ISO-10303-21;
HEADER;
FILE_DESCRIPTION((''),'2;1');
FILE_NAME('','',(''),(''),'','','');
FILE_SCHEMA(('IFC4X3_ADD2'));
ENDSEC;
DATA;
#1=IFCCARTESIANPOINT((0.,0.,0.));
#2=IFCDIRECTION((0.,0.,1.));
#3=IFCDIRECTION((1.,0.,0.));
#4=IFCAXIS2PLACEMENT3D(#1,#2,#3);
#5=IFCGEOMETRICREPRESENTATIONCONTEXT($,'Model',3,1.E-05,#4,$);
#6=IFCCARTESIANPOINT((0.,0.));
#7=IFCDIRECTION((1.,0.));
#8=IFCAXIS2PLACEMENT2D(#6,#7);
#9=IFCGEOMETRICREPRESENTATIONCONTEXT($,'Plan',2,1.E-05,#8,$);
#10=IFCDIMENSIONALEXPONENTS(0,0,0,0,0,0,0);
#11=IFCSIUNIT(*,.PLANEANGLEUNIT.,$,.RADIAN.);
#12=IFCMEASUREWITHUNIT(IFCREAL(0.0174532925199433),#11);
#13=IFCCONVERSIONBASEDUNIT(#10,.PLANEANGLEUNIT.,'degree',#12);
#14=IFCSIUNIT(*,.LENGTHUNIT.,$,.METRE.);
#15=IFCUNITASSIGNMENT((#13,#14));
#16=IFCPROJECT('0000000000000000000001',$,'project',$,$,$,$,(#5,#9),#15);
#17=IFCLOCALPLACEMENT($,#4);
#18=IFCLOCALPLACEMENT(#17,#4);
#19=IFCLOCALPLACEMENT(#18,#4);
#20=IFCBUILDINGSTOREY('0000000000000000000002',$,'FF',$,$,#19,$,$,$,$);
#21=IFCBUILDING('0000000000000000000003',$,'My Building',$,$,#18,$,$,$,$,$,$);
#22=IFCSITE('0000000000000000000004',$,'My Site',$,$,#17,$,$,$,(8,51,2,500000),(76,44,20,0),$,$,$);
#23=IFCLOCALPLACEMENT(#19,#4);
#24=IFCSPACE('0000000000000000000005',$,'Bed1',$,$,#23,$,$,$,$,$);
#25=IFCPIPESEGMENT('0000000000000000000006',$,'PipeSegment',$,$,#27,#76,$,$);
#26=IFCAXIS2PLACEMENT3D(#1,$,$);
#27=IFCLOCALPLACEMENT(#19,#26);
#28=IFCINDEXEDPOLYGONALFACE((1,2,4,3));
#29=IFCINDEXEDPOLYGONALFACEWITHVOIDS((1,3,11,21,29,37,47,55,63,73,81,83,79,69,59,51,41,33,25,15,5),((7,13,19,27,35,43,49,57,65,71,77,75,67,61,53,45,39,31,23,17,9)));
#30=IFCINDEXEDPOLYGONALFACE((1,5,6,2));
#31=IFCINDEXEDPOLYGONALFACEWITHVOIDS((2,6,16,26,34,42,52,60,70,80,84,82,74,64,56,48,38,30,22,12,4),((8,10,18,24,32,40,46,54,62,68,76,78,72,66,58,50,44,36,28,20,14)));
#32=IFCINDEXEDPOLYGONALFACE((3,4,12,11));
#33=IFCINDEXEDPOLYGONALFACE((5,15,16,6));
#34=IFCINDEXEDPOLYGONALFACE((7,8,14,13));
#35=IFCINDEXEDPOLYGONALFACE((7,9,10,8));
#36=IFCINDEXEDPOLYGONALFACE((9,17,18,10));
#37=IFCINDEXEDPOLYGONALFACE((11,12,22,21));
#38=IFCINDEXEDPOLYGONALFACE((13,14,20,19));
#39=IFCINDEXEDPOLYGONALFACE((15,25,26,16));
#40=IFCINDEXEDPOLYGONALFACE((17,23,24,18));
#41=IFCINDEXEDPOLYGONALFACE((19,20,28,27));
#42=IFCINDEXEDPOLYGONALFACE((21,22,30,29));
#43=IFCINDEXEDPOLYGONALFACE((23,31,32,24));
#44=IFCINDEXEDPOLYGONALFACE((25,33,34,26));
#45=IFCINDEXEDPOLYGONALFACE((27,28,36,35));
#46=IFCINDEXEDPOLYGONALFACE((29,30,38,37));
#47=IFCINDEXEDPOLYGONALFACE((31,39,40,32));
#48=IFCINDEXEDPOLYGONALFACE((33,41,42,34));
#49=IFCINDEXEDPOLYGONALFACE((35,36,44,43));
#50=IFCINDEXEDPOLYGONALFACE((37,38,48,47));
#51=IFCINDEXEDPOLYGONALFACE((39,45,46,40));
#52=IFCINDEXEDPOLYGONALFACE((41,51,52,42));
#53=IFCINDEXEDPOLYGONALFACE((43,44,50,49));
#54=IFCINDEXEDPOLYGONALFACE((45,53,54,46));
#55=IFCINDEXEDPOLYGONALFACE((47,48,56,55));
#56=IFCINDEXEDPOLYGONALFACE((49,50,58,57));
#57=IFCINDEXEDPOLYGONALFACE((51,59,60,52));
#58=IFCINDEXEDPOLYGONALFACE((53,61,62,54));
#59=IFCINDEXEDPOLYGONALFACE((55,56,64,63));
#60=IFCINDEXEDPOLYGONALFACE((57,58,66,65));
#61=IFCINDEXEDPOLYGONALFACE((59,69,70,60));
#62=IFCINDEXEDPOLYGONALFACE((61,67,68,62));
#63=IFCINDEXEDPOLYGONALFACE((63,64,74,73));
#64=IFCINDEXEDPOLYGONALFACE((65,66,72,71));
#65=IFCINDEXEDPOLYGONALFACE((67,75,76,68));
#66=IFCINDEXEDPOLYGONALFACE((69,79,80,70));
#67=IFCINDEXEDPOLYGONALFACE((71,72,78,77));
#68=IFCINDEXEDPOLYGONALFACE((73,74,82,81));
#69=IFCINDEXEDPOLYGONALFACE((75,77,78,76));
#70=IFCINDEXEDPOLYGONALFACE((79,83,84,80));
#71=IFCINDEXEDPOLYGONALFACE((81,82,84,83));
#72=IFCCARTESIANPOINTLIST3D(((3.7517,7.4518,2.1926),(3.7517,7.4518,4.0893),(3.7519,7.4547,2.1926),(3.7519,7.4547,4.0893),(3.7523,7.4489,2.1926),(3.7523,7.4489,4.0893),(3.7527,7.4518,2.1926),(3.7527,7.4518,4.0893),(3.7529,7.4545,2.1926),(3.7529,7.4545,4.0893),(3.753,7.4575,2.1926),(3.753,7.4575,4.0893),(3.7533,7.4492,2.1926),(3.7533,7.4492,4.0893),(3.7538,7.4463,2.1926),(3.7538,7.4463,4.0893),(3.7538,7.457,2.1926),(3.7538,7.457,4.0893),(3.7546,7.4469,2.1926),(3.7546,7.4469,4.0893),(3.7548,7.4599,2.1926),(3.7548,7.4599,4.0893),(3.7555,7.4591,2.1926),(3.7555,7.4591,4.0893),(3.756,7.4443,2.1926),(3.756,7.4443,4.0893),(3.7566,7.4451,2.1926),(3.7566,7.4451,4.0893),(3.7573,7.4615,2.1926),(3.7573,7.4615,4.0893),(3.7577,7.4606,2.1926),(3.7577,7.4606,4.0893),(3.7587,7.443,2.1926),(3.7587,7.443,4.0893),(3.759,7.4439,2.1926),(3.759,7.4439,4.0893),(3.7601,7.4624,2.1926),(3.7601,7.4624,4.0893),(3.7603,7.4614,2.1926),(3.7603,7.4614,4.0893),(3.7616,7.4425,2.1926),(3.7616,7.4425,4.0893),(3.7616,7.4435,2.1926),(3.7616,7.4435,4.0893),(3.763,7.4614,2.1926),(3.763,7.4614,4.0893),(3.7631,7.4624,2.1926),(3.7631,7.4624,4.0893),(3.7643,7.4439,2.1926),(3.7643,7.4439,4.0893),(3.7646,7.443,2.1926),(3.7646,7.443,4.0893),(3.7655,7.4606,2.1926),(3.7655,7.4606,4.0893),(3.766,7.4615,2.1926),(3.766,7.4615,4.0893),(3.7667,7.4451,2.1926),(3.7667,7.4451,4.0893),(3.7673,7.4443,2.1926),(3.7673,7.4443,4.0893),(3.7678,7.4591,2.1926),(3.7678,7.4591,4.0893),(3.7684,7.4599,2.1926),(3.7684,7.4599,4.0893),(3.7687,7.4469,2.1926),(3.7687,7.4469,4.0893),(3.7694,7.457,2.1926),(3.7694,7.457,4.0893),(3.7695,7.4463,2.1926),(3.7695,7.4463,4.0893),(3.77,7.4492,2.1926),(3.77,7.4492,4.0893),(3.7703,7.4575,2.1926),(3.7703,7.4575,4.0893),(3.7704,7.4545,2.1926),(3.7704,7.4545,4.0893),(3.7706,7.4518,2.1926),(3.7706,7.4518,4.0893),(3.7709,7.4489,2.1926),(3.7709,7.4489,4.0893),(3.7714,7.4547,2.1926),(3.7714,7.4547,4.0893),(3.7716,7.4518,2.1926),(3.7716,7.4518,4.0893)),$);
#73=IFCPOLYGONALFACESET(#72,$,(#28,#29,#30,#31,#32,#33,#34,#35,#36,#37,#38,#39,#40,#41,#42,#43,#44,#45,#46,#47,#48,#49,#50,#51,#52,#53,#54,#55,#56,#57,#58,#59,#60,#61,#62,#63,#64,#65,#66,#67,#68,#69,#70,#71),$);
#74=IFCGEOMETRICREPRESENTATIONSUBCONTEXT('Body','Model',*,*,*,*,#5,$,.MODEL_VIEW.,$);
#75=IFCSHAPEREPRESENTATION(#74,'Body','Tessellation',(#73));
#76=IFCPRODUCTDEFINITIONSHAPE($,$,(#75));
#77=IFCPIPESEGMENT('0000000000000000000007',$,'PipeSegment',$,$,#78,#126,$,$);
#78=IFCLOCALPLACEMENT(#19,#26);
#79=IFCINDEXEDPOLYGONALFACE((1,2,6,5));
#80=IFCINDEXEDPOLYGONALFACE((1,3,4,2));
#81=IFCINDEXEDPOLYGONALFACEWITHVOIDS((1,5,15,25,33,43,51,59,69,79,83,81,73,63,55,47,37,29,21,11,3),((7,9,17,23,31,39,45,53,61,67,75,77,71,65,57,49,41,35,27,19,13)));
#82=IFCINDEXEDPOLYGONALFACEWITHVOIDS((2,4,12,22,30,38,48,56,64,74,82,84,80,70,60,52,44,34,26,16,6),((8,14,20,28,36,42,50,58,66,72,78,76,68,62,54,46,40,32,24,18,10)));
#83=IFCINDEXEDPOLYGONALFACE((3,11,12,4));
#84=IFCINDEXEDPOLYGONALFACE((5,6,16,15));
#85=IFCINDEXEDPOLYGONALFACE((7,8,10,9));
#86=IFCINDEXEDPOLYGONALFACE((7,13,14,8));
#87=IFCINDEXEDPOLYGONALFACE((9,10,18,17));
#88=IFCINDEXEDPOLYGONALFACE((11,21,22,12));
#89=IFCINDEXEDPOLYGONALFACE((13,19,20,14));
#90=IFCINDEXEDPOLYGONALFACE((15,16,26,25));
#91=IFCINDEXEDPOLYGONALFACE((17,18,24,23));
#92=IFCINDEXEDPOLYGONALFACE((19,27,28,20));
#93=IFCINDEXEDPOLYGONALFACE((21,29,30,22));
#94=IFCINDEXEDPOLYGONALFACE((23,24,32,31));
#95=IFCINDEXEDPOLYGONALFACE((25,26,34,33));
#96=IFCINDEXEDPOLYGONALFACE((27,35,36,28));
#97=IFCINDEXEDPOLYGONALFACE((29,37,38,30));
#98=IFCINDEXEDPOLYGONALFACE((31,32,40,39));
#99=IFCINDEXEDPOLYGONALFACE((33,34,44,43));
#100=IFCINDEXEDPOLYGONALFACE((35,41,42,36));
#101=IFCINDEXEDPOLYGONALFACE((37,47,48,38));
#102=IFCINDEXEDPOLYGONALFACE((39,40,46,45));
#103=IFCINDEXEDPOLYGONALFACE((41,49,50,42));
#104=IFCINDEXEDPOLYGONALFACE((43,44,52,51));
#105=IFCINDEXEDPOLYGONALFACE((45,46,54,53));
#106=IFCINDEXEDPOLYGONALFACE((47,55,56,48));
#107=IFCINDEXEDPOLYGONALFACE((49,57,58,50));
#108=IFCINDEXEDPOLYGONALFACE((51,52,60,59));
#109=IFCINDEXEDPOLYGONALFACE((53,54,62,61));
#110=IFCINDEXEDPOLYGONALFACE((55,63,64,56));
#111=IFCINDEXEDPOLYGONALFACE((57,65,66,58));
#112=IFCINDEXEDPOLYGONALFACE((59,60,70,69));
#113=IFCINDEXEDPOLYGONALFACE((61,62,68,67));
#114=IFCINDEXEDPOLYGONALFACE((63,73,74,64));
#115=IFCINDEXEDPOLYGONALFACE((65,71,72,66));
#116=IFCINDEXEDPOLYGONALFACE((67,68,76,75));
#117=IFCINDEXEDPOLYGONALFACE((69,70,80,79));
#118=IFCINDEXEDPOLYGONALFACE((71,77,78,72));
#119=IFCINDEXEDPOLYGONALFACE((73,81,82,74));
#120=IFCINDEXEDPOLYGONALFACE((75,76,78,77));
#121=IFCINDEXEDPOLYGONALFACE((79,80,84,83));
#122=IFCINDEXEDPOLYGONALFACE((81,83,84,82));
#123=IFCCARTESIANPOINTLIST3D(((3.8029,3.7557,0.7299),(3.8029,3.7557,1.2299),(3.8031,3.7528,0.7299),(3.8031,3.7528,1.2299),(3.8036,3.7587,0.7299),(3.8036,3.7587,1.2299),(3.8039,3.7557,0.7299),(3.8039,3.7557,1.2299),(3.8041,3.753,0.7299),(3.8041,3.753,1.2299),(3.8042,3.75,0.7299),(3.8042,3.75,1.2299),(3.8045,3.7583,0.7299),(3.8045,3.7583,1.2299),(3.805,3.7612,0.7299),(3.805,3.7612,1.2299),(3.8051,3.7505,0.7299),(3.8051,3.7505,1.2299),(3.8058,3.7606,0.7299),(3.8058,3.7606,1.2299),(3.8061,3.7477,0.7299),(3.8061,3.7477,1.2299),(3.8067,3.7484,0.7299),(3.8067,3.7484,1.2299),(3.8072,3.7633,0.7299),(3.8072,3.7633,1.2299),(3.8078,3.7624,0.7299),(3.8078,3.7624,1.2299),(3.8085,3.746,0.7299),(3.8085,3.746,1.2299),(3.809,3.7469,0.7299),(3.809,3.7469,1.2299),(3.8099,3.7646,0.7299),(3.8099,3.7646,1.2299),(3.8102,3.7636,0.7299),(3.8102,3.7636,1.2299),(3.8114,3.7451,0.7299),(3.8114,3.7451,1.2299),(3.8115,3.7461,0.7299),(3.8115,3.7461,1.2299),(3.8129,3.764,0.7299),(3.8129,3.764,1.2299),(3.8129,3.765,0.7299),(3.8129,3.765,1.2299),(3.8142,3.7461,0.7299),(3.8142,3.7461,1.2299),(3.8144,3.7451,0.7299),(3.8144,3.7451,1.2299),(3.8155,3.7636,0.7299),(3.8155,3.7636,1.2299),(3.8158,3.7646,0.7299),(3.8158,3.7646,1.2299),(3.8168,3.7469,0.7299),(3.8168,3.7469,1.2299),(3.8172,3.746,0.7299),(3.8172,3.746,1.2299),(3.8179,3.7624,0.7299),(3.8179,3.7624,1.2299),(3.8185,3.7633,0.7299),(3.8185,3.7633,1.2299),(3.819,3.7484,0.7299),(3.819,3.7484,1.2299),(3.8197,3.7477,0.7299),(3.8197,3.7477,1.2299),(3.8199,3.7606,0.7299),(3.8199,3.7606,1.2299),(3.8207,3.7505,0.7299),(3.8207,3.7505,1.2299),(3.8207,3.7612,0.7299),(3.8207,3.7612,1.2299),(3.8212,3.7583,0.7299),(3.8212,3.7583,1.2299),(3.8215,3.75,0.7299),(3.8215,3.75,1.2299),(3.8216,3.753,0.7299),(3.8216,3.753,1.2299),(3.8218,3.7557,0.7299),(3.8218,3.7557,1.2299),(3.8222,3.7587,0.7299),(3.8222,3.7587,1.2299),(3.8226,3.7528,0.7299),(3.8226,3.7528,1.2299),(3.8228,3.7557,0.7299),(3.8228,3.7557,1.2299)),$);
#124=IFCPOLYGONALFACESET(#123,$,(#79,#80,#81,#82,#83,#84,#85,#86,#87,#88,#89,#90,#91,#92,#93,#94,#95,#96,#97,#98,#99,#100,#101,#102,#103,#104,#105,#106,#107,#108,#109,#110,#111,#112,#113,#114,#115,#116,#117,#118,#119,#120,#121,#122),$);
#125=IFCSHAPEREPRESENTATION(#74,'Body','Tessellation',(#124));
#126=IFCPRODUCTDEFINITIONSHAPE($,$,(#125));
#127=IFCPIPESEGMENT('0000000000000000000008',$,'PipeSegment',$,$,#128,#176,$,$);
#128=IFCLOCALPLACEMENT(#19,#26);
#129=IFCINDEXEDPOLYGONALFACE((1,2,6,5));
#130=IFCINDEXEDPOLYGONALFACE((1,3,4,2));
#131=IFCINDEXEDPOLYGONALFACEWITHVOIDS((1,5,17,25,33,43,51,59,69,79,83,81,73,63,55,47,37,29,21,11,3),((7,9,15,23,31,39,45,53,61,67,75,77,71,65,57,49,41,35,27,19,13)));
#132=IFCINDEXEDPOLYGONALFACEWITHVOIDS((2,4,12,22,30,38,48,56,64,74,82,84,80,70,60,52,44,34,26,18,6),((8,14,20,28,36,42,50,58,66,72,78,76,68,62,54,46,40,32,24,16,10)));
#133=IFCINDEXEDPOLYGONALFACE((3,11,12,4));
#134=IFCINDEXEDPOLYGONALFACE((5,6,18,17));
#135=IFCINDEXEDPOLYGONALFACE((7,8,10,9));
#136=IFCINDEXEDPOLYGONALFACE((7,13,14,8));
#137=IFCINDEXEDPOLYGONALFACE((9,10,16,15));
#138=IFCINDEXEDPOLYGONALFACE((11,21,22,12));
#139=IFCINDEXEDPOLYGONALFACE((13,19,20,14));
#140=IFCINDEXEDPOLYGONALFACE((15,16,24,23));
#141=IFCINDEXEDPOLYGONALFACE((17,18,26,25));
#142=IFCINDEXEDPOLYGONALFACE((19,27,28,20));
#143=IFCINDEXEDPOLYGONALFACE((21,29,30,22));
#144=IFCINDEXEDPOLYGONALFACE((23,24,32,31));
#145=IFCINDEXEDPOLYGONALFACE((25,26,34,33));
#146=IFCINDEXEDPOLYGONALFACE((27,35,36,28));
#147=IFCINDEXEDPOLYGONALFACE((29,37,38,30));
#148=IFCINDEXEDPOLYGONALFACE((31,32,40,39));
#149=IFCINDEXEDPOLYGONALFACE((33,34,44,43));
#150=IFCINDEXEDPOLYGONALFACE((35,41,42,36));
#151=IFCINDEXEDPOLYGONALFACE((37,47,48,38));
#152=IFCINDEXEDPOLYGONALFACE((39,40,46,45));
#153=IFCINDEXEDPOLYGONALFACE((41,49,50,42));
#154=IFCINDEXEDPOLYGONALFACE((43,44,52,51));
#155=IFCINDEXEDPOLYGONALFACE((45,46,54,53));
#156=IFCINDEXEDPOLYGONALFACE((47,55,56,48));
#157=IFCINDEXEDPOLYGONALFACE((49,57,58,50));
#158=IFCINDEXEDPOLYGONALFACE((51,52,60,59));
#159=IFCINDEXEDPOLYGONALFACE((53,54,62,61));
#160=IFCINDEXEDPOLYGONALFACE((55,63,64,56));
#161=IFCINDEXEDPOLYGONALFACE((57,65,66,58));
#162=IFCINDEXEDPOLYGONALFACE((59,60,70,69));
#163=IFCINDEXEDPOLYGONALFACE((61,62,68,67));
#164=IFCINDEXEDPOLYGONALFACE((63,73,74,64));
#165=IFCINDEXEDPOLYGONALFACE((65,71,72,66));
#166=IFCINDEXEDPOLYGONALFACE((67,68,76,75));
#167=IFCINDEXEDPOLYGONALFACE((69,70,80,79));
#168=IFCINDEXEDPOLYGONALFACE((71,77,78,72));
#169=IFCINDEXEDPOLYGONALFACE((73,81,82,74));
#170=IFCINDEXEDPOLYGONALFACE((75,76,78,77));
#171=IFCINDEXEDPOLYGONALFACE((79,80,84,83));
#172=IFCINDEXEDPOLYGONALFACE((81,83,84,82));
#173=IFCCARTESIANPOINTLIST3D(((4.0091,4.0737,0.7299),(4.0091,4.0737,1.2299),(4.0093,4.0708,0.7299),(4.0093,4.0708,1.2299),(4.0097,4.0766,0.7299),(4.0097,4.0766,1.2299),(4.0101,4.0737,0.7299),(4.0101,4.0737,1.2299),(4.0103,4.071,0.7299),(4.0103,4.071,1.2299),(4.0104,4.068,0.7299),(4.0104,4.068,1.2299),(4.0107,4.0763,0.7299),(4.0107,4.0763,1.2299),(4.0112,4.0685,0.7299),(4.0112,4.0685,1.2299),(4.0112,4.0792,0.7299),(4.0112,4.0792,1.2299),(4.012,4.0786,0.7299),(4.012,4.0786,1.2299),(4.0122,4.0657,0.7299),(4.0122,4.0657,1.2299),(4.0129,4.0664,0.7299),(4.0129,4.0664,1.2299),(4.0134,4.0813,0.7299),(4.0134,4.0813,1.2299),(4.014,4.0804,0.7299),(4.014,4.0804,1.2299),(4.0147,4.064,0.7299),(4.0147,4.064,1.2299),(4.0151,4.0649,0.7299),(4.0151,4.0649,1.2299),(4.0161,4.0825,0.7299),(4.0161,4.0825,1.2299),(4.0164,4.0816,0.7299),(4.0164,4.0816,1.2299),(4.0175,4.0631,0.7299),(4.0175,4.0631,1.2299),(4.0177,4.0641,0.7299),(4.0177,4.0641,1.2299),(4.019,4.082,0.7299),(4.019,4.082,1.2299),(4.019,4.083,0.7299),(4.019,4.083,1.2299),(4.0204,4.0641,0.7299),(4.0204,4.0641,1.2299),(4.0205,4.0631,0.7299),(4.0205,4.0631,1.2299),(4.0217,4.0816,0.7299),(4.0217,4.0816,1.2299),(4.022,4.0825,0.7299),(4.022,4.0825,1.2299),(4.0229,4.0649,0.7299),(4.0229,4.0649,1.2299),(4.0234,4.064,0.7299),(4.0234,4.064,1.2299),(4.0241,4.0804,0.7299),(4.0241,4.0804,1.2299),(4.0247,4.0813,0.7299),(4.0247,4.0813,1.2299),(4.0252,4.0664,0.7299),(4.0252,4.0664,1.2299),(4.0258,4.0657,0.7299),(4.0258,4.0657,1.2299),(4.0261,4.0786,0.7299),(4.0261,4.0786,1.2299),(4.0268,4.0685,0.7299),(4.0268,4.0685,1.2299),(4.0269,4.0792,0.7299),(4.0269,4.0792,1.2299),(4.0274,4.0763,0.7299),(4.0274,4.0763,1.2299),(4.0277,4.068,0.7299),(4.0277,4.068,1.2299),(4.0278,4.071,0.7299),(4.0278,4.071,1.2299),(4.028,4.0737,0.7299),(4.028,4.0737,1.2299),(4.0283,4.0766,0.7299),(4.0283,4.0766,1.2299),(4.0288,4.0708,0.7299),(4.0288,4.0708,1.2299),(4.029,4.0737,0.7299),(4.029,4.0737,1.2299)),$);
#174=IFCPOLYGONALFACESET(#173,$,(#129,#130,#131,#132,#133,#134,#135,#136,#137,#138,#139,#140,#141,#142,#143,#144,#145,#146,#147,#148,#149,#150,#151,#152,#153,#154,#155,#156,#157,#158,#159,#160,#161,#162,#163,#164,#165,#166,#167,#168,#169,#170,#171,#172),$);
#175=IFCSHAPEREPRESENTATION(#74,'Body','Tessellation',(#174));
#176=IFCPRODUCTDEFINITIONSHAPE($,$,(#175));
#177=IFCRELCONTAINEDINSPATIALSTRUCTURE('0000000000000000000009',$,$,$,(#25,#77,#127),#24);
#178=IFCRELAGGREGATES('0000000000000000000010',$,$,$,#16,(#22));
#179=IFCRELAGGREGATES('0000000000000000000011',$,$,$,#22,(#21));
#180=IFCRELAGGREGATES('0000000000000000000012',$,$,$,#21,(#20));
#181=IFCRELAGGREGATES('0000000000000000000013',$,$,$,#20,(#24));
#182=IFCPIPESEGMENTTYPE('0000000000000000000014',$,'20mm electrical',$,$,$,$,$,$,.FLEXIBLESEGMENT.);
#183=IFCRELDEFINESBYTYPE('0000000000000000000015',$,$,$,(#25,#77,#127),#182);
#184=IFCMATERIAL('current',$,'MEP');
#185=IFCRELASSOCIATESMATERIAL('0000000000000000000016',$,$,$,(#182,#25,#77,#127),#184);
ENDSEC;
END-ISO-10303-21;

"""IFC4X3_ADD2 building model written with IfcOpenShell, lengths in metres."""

from ifc_helpers import new_model, entity, si_unit, converted_unit, frame, origin_with_axes, origin_2d_with_axis, place, context, subcontext, project, spatial, hollow_circle, extrude, material, material_profile, profile_set, profile_usage, type_object, element, save


model = new_model("IFC4X3_ADD2")

# Units and contexts
model_context = context("Model", 3, precision=1e-05, world=origin_with_axes())
plan_context = context("Plan", 2, precision=1e-05, world=origin_2d_with_axis())
body_context_1 = subcontext(model_context, "Body", "Model", "MODEL_VIEW")
ifc_project = project(units=[converted_unit("PLANEANGLEUNIT", "degree", entity("IfcReal", 0.0174532925199433), si_unit("PLANEANGLEUNIT", "RADIAN"), dimensions=[0, 0, 0, 0, 0, 0, 0]), si_unit("LENGTHUNIT", "METRE")], contexts=[model_context, plan_context])

# Site, building, storey
site_placement = place(None, origin_with_axes())
site = spatial("IfcSite", under=ifc_project, at=site_placement, Name="My Site", RefLatitude=(8, 51, 2, 500000), RefLongitude=(76, 44, 20, 0))
building_placement = place(site_placement, origin_with_axes())
building = spatial("IfcBuilding", under=site, at=building_placement, Name="My Building")
storey_placement = place(building_placement, origin_with_axes())
storey = spatial("IfcBuildingStorey", under=building, at=storey_placement, Name="FF")

# Shared definitions
space_1_placement = place(storey_placement, origin_with_axes())
space_1 = spatial("IfcSpace", under=storey, at=space_1_placement, Name="Bed1")

# Pipe segments
ifc_material_1 = material(Name="current", Category="MEP")
ifc_material_profile_1 = material_profile(ifc_material_1, hollow_circle(Radius=0.01, WallThickness=0.001))
ifc_profile_set_1 = profile_set([ifc_material_profile_1], Name="current")
pipe_segment_type = type_object("IfcPipeSegmentType", Name="20mm electrical", PredefinedType="FLEXIBLESEGMENT", material=ifc_profile_set_1)
ifc_profile_usage_1 = profile_usage(ifc_profile_set_1, cardinal=5)
pipe_segment_1_placement = place(space_1_placement, frame((3.7616, 7.4525, 2.1926), z_axis=(0.0, 0.0, 1.0), x_axis=(0.0, -1.0, 0.0)))
element("IfcPipeSegment", 1, at=pipe_segment_1_placement, inside=space_1, type_object=pipe_segment_type, material=ifc_profile_usage_1, Name="PipeSegment", context=body_context_1, shape_type="SweptSolid", body=[
    extrude(hollow_circle(Radius=0.01, WallThickness=0.001), origin_with_axes(), (0.0, 0.0, 1.0), 1.8967),
])
ifc_profile_usage_2 = profile_usage(ifc_profile_set_1, cardinal=5)
pipe_segment_2_placement = place(space_1_placement, frame((3.8129, 3.755, 0.7299), z_axis=(0.0, 0.0, 1.0), x_axis=(0.0, 1.0, 0.0)))
element("IfcPipeSegment", 2, at=pipe_segment_2_placement, inside=space_1, type_object=pipe_segment_type, material=ifc_profile_usage_2, Name="PipeSegment", context=body_context_1, shape_type="SweptSolid", body=[
    extrude(hollow_circle(Radius=0.01, WallThickness=0.001), origin_with_axes(), (0.0, 0.0, 1.0), 0.5),
])
ifc_profile_usage_3 = profile_usage(ifc_profile_set_1, cardinal=5)
pipe_segment_3_placement = place(space_1_placement, frame((4.019, 4.073, 0.7299), z_axis=(0.0, 0.0, 1.0), x_axis=(0.0, 1.0, 0.0)))
element("IfcPipeSegment", 3, at=pipe_segment_3_placement, inside=space_1, type_object=pipe_segment_type, material=ifc_profile_usage_3, Name="PipeSegment", context=body_context_1, shape_type="SweptSolid", body=[
    extrude(hollow_circle(Radius=0.01, WallThickness=0.001), origin_with_axes(), (0.0, 0.0, 1.0), 0.5),
])

save(model, "model.ifc")
